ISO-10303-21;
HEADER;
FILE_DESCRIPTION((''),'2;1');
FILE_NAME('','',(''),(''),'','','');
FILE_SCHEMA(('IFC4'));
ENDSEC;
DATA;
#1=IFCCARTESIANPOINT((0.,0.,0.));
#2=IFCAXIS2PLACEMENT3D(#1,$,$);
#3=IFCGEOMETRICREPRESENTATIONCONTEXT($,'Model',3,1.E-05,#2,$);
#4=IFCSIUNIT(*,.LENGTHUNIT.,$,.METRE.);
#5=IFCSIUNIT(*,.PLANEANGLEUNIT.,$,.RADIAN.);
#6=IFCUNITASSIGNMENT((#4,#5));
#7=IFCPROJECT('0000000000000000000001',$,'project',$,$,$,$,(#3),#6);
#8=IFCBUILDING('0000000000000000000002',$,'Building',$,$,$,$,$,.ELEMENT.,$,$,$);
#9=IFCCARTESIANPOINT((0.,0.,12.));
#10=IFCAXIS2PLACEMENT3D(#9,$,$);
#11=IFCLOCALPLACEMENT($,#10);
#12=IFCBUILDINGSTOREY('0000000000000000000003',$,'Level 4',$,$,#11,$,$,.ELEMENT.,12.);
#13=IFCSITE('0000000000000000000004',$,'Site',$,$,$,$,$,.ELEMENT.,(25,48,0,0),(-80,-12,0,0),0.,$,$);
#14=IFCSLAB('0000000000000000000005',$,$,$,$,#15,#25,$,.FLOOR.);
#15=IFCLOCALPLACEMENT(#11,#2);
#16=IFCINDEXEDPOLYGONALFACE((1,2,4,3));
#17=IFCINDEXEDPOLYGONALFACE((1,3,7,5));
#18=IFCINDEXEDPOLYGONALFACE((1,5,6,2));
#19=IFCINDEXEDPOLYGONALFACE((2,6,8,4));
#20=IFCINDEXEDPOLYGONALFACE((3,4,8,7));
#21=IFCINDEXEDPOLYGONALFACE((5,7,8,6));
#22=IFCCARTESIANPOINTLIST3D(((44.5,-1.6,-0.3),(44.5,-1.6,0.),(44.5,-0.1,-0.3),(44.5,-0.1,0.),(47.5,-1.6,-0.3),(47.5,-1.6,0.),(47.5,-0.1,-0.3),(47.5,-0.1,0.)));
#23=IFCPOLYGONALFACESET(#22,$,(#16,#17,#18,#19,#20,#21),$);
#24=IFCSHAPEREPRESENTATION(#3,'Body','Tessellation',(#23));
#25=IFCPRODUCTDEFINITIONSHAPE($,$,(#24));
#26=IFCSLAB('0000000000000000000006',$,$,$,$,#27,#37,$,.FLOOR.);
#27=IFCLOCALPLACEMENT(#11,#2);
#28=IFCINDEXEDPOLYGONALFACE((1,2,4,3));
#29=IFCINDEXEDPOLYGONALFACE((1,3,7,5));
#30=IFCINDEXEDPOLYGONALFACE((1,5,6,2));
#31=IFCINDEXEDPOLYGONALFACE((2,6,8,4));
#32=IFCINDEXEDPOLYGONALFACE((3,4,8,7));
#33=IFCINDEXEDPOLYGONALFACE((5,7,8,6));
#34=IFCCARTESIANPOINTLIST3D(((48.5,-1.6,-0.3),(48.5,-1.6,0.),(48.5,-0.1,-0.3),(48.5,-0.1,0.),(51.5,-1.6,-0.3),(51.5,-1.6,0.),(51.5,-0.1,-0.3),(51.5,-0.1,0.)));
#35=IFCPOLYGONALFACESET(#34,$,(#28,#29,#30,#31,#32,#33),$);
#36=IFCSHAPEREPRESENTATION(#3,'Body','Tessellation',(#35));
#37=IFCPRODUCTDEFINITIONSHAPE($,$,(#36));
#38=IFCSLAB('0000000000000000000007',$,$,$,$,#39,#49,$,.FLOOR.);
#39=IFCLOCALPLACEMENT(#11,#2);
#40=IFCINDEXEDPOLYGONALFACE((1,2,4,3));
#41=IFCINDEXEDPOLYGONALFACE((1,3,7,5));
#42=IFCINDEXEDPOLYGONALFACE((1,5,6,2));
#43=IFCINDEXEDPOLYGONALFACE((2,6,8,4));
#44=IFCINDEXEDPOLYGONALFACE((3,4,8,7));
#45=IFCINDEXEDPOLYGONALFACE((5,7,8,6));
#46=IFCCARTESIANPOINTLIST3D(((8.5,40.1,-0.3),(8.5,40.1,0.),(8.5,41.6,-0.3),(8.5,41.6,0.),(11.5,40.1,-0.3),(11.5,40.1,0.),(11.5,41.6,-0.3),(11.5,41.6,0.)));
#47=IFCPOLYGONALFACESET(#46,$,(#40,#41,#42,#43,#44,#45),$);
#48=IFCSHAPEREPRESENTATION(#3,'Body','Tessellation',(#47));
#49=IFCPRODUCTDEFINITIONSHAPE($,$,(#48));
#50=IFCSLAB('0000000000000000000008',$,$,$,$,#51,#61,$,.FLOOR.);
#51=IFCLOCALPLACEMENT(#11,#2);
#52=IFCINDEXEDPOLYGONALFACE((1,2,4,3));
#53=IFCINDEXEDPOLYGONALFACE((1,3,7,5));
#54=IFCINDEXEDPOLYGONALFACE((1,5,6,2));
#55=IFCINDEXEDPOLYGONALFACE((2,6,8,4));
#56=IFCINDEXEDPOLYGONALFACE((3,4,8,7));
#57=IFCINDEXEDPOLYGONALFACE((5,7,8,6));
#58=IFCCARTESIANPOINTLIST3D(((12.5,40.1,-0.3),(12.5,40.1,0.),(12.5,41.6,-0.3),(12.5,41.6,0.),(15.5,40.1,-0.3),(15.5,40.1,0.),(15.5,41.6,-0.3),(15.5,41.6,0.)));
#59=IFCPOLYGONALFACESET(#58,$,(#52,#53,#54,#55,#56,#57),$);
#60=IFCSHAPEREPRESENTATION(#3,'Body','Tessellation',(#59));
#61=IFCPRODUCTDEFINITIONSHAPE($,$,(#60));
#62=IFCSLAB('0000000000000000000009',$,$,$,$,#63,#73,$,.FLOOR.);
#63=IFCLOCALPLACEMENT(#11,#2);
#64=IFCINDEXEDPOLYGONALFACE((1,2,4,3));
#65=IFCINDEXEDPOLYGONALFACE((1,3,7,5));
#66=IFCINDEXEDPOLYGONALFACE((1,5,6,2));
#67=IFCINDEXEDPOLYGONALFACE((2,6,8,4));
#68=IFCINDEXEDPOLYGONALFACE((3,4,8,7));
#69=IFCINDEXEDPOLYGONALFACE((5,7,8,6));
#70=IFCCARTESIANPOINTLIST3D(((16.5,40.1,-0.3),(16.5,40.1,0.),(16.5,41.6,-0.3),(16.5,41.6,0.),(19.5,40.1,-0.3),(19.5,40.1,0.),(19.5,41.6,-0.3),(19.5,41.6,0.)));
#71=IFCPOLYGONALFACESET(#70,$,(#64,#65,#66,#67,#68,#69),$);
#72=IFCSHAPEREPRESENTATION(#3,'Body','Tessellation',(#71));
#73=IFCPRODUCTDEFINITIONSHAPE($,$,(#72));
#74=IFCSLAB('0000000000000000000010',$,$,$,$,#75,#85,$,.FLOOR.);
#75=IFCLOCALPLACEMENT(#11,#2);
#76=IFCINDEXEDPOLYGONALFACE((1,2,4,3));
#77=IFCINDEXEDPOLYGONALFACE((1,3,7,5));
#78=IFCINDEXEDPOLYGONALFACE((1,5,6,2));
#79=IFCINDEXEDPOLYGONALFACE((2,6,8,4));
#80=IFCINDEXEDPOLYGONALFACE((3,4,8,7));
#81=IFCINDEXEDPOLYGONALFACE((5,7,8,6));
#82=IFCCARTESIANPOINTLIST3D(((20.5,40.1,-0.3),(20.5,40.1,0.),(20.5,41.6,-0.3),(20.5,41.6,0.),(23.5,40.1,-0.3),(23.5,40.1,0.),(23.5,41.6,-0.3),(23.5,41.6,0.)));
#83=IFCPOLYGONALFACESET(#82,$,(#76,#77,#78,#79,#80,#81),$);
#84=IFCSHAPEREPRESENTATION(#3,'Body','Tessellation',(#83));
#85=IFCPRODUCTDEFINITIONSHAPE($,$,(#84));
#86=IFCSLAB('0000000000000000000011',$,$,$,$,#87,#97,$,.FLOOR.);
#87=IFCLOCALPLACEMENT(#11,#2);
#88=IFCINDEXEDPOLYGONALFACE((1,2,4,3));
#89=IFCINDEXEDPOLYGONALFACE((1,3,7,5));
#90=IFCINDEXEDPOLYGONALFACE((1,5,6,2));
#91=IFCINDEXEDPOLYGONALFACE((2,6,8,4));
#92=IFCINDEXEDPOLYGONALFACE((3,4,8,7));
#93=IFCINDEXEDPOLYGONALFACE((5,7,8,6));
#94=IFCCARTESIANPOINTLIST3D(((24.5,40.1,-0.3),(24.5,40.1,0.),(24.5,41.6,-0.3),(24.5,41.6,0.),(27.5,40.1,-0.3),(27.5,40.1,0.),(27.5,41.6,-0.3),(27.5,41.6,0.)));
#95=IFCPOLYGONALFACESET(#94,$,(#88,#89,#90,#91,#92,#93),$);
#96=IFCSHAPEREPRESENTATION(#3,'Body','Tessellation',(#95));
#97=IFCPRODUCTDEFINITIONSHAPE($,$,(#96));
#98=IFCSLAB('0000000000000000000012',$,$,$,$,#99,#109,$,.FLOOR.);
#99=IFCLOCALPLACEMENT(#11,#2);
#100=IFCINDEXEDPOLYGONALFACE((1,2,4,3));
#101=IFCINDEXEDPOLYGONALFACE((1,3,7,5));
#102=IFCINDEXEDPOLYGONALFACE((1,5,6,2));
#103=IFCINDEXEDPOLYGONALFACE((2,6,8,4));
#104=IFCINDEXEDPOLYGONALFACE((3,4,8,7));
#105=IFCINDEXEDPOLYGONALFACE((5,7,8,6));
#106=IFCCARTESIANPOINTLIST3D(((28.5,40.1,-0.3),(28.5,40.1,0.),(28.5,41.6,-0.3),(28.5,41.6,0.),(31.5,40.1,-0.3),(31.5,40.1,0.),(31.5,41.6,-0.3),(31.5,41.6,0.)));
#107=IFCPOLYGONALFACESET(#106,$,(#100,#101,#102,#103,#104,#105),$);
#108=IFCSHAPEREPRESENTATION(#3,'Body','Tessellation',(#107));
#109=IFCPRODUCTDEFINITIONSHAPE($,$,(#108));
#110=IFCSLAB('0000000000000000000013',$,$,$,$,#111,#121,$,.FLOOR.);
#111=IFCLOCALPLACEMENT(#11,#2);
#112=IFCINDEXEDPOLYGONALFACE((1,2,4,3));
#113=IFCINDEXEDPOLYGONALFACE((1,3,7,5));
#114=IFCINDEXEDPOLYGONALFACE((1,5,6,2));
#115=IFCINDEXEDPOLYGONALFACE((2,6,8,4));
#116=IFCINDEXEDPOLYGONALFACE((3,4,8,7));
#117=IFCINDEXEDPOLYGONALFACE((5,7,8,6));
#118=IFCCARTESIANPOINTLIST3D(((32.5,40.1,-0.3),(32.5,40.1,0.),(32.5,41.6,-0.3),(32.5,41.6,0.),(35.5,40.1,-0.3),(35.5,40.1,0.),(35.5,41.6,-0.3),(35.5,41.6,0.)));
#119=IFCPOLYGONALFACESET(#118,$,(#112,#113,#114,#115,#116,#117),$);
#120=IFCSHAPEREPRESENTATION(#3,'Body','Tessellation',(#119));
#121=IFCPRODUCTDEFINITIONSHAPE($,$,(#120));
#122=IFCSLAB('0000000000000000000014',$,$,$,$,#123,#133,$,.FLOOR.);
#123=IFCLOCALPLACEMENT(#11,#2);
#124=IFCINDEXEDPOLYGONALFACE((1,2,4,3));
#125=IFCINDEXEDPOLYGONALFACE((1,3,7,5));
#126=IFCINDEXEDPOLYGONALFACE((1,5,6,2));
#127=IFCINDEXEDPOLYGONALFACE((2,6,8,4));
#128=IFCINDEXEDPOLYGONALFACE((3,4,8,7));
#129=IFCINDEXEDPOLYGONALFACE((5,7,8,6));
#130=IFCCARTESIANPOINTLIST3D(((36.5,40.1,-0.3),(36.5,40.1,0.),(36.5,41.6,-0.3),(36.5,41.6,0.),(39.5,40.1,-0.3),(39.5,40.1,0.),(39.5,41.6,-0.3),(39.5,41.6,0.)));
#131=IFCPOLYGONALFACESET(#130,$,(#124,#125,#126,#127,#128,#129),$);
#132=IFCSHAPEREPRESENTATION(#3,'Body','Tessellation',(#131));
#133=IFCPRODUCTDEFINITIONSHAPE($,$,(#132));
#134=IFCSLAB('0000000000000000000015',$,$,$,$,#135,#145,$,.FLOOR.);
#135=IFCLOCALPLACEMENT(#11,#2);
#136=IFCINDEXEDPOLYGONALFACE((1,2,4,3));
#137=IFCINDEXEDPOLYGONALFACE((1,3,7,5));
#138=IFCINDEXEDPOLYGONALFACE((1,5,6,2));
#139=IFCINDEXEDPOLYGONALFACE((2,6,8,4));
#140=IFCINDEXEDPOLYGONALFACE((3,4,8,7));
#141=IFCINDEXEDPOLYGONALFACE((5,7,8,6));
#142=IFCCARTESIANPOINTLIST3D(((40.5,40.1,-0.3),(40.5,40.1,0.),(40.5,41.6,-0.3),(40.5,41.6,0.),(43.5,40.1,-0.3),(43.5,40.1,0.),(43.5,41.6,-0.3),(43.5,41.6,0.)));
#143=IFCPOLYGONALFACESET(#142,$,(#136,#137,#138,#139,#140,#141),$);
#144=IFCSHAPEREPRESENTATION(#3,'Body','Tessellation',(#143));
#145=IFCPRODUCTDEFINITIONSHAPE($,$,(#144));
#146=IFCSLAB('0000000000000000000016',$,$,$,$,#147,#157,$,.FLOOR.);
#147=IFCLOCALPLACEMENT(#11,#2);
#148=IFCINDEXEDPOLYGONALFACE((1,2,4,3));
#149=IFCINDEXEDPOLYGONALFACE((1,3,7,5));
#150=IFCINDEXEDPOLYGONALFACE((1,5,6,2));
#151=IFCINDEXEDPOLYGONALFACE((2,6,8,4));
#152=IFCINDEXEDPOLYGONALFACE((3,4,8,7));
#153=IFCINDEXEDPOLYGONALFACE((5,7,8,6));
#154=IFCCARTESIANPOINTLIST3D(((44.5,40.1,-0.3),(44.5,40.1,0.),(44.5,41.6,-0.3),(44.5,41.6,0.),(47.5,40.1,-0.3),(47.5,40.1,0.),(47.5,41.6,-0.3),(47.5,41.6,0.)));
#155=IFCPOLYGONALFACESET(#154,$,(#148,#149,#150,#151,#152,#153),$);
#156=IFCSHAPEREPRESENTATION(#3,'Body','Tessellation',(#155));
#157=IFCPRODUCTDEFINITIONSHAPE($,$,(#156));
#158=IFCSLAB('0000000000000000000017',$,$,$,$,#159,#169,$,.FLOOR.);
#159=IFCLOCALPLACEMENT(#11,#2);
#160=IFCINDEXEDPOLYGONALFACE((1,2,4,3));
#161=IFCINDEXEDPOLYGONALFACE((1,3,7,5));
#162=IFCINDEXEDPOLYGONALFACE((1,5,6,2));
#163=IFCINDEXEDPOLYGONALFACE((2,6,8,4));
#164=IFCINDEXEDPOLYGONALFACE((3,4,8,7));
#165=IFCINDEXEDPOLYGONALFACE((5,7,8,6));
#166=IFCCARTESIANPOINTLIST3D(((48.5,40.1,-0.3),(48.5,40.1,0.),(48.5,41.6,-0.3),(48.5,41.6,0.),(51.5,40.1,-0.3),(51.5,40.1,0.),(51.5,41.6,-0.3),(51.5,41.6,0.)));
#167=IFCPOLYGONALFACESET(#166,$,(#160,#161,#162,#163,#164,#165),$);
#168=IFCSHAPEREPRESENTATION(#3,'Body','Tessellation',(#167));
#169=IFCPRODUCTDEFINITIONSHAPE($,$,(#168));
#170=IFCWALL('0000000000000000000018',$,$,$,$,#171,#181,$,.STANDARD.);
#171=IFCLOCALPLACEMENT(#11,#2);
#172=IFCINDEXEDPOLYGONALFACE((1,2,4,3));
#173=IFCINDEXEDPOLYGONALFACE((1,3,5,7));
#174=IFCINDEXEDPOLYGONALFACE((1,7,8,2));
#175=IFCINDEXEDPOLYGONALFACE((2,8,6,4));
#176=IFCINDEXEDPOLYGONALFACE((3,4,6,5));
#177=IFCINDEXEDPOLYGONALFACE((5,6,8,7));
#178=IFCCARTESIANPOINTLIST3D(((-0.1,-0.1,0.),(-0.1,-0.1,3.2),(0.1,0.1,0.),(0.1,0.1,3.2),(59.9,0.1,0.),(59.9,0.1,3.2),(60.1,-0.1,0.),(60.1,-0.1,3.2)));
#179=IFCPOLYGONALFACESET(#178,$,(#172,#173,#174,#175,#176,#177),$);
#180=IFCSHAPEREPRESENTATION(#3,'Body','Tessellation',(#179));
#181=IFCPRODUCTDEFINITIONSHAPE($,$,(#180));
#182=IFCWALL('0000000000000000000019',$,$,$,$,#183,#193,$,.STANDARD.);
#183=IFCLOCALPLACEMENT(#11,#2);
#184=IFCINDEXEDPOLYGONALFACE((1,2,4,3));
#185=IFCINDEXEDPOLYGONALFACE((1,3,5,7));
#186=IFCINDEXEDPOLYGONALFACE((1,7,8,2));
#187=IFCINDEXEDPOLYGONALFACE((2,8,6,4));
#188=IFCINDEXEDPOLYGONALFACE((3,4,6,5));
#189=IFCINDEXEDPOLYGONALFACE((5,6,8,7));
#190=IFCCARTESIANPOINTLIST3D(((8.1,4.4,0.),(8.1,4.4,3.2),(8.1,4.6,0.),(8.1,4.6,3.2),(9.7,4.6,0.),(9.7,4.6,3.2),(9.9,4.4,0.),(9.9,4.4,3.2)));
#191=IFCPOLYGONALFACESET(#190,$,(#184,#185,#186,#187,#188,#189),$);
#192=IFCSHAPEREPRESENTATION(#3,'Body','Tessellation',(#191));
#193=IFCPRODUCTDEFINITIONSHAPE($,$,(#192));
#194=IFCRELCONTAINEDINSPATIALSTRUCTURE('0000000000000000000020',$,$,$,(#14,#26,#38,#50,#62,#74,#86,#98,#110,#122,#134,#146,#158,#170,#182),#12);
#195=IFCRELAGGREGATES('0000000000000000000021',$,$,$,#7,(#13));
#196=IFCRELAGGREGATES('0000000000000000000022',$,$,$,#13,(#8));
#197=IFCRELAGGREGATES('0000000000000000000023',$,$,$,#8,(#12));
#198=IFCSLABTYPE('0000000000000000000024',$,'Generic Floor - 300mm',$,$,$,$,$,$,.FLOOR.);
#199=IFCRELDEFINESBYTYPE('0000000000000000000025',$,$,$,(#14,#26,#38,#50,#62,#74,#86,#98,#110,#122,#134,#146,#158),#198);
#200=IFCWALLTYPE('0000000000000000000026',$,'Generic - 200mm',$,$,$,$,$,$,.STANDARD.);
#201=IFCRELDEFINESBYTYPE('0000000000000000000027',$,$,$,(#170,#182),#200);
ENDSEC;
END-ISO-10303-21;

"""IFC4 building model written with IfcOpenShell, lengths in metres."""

from ifc_helpers import new_model, si_unit, frame, origin, place, context, project, spatial, polyline, outline, extrude, type_object, element, save


model = new_model("IFC4")

# Units and contexts
model_context = context("Model", 3, precision=1e-05, world=origin())
ifc_project = project(units=[si_unit("LENGTHUNIT", "METRE"), si_unit("PLANEANGLEUNIT", "RADIAN")], contexts=[model_context])

# Site, building, storey
site = spatial("IfcSite", under=ifc_project, Name="Site", CompositionType="ELEMENT", RefLatitude=(25, 48, 0, 0), RefLongitude=(-80, -12, 0, 0), RefElevation=0.0)
building = spatial("IfcBuilding", under=site, Name="Building", CompositionType="ELEMENT")
storey_placement = place(None, frame((0.0, 0.0, 12.0)))
storey = spatial("IfcBuildingStorey", under=building, at=storey_placement, Name="Level 4", CompositionType="ELEMENT", Elevation=12.0)

# Shared definitions
slab_type = type_object("IfcSlabType", Name="Generic Floor - 300mm", PredefinedType="FLOOR")

# Slabs
slab_1_placement = place(None, frame((0.0, 0.0, 12.0)))
element("IfcSlab", 1, at=slab_1_placement, inside=storey, type_object=slab_type, PredefinedType="FLOOR", context=model_context, shape_type="SweptSolid", body=[
    extrude(outline(polyline([(44.5, -0.1), (44.5, -1.6), (47.5, -1.6), (47.5, -0.1), (44.5, -0.1)])), origin(), (0.0, 0.0, -1.0), 0.3),
])
slab_2_placement = place(None, frame((0.0, 0.0, 12.0)))
element("IfcSlab", 2, at=slab_2_placement, inside=storey, type_object=slab_type, PredefinedType="FLOOR", context=model_context, shape_type="SweptSolid", body=[
    extrude(outline(polyline([(51.5, -0.1), (48.5, -0.1), (48.5, -1.6), (51.5, -1.6), (51.5, -0.1)])), origin(), (0.0, 0.0, -1.0), 0.3),
])
slab_3_placement = place(None, frame((0.0, 0.0, 12.0)))
element("IfcSlab", 3, at=slab_3_placement, inside=storey, type_object=slab_type, PredefinedType="FLOOR", context=model_context, shape_type="SweptSolid", body=[
    extrude(outline(polyline([(8.5, 40.1), (11.5, 40.1), (11.5, 41.6), (8.5, 41.6), (8.5, 40.1)])), origin(), (0.0, 0.0, -1.0), 0.3),
])
slab_4_placement = place(None, frame((0.0, 0.0, 12.0)))
element("IfcSlab", 4, at=slab_4_placement, inside=storey, type_object=slab_type, PredefinedType="FLOOR", context=model_context, shape_type="SweptSolid", body=[
    extrude(outline(polyline([(15.5, 40.1), (15.5, 41.6), (12.5, 41.6), (12.5, 40.1), (15.5, 40.1)])), origin(), (0.0, 0.0, -1.0), 0.3),
])
slab_5_placement = place(None, frame((0.0, 0.0, 12.0)))
element("IfcSlab", 5, at=slab_5_placement, inside=storey, type_object=slab_type, PredefinedType="FLOOR", context=model_context, shape_type="SweptSolid", body=[
    extrude(outline(polyline([(16.5, 40.1), (19.5, 40.1), (19.5, 41.6), (16.5, 41.6), (16.5, 40.1)])), origin(), (0.0, 0.0, -1.0), 0.3),
])
slab_6_placement = place(None, frame((0.0, 0.0, 12.0)))
element("IfcSlab", 6, at=slab_6_placement, inside=storey, type_object=slab_type, PredefinedType="FLOOR", context=model_context, shape_type="SweptSolid", body=[
    extrude(outline(polyline([(23.5, 40.1), (23.5, 41.6), (20.5, 41.6), (20.5, 40.1), (23.5, 40.1)])), origin(), (0.0, 0.0, -1.0), 0.3),
])
slab_7_placement = place(None, frame((0.0, 0.0, 12.0)))
element("IfcSlab", 7, at=slab_7_placement, inside=storey, type_object=slab_type, PredefinedType="FLOOR", context=model_context, shape_type="SweptSolid", body=[
    extrude(outline(polyline([(24.5, 40.1), (27.5, 40.1), (27.5, 41.6), (24.5, 41.6), (24.5, 40.1)])), origin(), (0.0, 0.0, -1.0), 0.3),
])
slab_8_placement = place(None, frame((0.0, 0.0, 12.0)))
element("IfcSlab", 8, at=slab_8_placement, inside=storey, type_object=slab_type, PredefinedType="FLOOR", context=model_context, shape_type="SweptSolid", body=[
    extrude(outline(polyline([(31.5, 40.1), (31.5, 41.6), (28.5, 41.6), (28.5, 40.1), (31.5, 40.1)])), origin(), (0.0, 0.0, -1.0), 0.3),
])
slab_9_placement = place(None, frame((0.0, 0.0, 12.0)))
element("IfcSlab", 9, at=slab_9_placement, inside=storey, type_object=slab_type, PredefinedType="FLOOR", context=model_context, shape_type="SweptSolid", body=[
    extrude(outline(polyline([(32.5, 40.1), (35.5, 40.1), (35.5, 41.6), (32.5, 41.6), (32.5, 40.1)])), origin(), (0.0, 0.0, -1.0), 0.3),
])
slab_10_placement = place(None, frame((0.0, 0.0, 12.0)))
element("IfcSlab", 10, at=slab_10_placement, inside=storey, type_object=slab_type, PredefinedType="FLOOR", context=model_context, shape_type="SweptSolid", body=[
    extrude(outline(polyline([(39.5, 40.1), (39.5, 41.6), (36.5, 41.6), (36.5, 40.1), (39.5, 40.1)])), origin(), (0.0, 0.0, -1.0), 0.3),
])
slab_11_placement = place(None, frame((0.0, 0.0, 12.0)))
element("IfcSlab", 11, at=slab_11_placement, inside=storey, type_object=slab_type, PredefinedType="FLOOR", context=model_context, shape_type="SweptSolid", body=[
    extrude(outline(polyline([(40.5, 40.1), (43.5, 40.1), (43.5, 41.6), (40.5, 41.6), (40.5, 40.1)])), origin(), (0.0, 0.0, -1.0), 0.3),
])
slab_12_placement = place(None, frame((0.0, 0.0, 12.0)))
element("IfcSlab", 12, at=slab_12_placement, inside=storey, type_object=slab_type, PredefinedType="FLOOR", context=model_context, shape_type="SweptSolid", body=[
    extrude(outline(polyline([(47.5, 40.1), (47.5, 41.6), (44.5, 41.6), (44.5, 40.1), (47.5, 40.1)])), origin(), (0.0, 0.0, -1.0), 0.3),
])
slab_13_placement = place(None, frame((0.0, 0.0, 12.0)))
element("IfcSlab", 13, at=slab_13_placement, inside=storey, type_object=slab_type, PredefinedType="FLOOR", context=model_context, shape_type="SweptSolid", body=[
    extrude(outline(polyline([(48.5, 40.1), (51.5, 40.1), (51.5, 41.6), (48.5, 41.6), (48.5, 40.1)])), origin(), (0.0, 0.0, -1.0), 0.3),
])

# Walls
wall_type = type_object("IfcWallType", Name="Generic - 200mm", PredefinedType="STANDARD")
wall_1_placement = place(None, frame((0.0, 0.0, 12.0), z_axis=(0.0, 0.0, 1.0), x_axis=(1.0, 0.0, 0.0)))
element("IfcWall", 14, at=wall_1_placement, inside=storey, type_object=wall_type, PredefinedType="STANDARD", context=model_context, shape_type="SweptSolid", body=[
    extrude(outline(polyline([(-0.1, -0.1), (60.1, -0.1), (59.9, 0.1), (0.1, 0.1), (-0.1, -0.1)])), origin(), (0.0, 0.0, 1.0), 3.2),
])
wall_2_placement = place(None, frame((9.8, 4.5, 12.0), z_axis=(0.0, 0.0, 1.0), x_axis=(-1.0, 0.0, 0.0)))
element("IfcWall", 15, at=wall_2_placement, inside=storey, type_object=wall_type, PredefinedType="STANDARD", context=model_context, shape_type="SweptSolid", body=[
    extrude(outline(polyline([(0.1, -0.1), (1.7, -0.1), (1.7, 0.1), (-0.1, 0.1), (0.1, -0.1)])), origin(), (0.0, 0.0, 1.0), 3.2),
])

save(model, "model.ifc")
